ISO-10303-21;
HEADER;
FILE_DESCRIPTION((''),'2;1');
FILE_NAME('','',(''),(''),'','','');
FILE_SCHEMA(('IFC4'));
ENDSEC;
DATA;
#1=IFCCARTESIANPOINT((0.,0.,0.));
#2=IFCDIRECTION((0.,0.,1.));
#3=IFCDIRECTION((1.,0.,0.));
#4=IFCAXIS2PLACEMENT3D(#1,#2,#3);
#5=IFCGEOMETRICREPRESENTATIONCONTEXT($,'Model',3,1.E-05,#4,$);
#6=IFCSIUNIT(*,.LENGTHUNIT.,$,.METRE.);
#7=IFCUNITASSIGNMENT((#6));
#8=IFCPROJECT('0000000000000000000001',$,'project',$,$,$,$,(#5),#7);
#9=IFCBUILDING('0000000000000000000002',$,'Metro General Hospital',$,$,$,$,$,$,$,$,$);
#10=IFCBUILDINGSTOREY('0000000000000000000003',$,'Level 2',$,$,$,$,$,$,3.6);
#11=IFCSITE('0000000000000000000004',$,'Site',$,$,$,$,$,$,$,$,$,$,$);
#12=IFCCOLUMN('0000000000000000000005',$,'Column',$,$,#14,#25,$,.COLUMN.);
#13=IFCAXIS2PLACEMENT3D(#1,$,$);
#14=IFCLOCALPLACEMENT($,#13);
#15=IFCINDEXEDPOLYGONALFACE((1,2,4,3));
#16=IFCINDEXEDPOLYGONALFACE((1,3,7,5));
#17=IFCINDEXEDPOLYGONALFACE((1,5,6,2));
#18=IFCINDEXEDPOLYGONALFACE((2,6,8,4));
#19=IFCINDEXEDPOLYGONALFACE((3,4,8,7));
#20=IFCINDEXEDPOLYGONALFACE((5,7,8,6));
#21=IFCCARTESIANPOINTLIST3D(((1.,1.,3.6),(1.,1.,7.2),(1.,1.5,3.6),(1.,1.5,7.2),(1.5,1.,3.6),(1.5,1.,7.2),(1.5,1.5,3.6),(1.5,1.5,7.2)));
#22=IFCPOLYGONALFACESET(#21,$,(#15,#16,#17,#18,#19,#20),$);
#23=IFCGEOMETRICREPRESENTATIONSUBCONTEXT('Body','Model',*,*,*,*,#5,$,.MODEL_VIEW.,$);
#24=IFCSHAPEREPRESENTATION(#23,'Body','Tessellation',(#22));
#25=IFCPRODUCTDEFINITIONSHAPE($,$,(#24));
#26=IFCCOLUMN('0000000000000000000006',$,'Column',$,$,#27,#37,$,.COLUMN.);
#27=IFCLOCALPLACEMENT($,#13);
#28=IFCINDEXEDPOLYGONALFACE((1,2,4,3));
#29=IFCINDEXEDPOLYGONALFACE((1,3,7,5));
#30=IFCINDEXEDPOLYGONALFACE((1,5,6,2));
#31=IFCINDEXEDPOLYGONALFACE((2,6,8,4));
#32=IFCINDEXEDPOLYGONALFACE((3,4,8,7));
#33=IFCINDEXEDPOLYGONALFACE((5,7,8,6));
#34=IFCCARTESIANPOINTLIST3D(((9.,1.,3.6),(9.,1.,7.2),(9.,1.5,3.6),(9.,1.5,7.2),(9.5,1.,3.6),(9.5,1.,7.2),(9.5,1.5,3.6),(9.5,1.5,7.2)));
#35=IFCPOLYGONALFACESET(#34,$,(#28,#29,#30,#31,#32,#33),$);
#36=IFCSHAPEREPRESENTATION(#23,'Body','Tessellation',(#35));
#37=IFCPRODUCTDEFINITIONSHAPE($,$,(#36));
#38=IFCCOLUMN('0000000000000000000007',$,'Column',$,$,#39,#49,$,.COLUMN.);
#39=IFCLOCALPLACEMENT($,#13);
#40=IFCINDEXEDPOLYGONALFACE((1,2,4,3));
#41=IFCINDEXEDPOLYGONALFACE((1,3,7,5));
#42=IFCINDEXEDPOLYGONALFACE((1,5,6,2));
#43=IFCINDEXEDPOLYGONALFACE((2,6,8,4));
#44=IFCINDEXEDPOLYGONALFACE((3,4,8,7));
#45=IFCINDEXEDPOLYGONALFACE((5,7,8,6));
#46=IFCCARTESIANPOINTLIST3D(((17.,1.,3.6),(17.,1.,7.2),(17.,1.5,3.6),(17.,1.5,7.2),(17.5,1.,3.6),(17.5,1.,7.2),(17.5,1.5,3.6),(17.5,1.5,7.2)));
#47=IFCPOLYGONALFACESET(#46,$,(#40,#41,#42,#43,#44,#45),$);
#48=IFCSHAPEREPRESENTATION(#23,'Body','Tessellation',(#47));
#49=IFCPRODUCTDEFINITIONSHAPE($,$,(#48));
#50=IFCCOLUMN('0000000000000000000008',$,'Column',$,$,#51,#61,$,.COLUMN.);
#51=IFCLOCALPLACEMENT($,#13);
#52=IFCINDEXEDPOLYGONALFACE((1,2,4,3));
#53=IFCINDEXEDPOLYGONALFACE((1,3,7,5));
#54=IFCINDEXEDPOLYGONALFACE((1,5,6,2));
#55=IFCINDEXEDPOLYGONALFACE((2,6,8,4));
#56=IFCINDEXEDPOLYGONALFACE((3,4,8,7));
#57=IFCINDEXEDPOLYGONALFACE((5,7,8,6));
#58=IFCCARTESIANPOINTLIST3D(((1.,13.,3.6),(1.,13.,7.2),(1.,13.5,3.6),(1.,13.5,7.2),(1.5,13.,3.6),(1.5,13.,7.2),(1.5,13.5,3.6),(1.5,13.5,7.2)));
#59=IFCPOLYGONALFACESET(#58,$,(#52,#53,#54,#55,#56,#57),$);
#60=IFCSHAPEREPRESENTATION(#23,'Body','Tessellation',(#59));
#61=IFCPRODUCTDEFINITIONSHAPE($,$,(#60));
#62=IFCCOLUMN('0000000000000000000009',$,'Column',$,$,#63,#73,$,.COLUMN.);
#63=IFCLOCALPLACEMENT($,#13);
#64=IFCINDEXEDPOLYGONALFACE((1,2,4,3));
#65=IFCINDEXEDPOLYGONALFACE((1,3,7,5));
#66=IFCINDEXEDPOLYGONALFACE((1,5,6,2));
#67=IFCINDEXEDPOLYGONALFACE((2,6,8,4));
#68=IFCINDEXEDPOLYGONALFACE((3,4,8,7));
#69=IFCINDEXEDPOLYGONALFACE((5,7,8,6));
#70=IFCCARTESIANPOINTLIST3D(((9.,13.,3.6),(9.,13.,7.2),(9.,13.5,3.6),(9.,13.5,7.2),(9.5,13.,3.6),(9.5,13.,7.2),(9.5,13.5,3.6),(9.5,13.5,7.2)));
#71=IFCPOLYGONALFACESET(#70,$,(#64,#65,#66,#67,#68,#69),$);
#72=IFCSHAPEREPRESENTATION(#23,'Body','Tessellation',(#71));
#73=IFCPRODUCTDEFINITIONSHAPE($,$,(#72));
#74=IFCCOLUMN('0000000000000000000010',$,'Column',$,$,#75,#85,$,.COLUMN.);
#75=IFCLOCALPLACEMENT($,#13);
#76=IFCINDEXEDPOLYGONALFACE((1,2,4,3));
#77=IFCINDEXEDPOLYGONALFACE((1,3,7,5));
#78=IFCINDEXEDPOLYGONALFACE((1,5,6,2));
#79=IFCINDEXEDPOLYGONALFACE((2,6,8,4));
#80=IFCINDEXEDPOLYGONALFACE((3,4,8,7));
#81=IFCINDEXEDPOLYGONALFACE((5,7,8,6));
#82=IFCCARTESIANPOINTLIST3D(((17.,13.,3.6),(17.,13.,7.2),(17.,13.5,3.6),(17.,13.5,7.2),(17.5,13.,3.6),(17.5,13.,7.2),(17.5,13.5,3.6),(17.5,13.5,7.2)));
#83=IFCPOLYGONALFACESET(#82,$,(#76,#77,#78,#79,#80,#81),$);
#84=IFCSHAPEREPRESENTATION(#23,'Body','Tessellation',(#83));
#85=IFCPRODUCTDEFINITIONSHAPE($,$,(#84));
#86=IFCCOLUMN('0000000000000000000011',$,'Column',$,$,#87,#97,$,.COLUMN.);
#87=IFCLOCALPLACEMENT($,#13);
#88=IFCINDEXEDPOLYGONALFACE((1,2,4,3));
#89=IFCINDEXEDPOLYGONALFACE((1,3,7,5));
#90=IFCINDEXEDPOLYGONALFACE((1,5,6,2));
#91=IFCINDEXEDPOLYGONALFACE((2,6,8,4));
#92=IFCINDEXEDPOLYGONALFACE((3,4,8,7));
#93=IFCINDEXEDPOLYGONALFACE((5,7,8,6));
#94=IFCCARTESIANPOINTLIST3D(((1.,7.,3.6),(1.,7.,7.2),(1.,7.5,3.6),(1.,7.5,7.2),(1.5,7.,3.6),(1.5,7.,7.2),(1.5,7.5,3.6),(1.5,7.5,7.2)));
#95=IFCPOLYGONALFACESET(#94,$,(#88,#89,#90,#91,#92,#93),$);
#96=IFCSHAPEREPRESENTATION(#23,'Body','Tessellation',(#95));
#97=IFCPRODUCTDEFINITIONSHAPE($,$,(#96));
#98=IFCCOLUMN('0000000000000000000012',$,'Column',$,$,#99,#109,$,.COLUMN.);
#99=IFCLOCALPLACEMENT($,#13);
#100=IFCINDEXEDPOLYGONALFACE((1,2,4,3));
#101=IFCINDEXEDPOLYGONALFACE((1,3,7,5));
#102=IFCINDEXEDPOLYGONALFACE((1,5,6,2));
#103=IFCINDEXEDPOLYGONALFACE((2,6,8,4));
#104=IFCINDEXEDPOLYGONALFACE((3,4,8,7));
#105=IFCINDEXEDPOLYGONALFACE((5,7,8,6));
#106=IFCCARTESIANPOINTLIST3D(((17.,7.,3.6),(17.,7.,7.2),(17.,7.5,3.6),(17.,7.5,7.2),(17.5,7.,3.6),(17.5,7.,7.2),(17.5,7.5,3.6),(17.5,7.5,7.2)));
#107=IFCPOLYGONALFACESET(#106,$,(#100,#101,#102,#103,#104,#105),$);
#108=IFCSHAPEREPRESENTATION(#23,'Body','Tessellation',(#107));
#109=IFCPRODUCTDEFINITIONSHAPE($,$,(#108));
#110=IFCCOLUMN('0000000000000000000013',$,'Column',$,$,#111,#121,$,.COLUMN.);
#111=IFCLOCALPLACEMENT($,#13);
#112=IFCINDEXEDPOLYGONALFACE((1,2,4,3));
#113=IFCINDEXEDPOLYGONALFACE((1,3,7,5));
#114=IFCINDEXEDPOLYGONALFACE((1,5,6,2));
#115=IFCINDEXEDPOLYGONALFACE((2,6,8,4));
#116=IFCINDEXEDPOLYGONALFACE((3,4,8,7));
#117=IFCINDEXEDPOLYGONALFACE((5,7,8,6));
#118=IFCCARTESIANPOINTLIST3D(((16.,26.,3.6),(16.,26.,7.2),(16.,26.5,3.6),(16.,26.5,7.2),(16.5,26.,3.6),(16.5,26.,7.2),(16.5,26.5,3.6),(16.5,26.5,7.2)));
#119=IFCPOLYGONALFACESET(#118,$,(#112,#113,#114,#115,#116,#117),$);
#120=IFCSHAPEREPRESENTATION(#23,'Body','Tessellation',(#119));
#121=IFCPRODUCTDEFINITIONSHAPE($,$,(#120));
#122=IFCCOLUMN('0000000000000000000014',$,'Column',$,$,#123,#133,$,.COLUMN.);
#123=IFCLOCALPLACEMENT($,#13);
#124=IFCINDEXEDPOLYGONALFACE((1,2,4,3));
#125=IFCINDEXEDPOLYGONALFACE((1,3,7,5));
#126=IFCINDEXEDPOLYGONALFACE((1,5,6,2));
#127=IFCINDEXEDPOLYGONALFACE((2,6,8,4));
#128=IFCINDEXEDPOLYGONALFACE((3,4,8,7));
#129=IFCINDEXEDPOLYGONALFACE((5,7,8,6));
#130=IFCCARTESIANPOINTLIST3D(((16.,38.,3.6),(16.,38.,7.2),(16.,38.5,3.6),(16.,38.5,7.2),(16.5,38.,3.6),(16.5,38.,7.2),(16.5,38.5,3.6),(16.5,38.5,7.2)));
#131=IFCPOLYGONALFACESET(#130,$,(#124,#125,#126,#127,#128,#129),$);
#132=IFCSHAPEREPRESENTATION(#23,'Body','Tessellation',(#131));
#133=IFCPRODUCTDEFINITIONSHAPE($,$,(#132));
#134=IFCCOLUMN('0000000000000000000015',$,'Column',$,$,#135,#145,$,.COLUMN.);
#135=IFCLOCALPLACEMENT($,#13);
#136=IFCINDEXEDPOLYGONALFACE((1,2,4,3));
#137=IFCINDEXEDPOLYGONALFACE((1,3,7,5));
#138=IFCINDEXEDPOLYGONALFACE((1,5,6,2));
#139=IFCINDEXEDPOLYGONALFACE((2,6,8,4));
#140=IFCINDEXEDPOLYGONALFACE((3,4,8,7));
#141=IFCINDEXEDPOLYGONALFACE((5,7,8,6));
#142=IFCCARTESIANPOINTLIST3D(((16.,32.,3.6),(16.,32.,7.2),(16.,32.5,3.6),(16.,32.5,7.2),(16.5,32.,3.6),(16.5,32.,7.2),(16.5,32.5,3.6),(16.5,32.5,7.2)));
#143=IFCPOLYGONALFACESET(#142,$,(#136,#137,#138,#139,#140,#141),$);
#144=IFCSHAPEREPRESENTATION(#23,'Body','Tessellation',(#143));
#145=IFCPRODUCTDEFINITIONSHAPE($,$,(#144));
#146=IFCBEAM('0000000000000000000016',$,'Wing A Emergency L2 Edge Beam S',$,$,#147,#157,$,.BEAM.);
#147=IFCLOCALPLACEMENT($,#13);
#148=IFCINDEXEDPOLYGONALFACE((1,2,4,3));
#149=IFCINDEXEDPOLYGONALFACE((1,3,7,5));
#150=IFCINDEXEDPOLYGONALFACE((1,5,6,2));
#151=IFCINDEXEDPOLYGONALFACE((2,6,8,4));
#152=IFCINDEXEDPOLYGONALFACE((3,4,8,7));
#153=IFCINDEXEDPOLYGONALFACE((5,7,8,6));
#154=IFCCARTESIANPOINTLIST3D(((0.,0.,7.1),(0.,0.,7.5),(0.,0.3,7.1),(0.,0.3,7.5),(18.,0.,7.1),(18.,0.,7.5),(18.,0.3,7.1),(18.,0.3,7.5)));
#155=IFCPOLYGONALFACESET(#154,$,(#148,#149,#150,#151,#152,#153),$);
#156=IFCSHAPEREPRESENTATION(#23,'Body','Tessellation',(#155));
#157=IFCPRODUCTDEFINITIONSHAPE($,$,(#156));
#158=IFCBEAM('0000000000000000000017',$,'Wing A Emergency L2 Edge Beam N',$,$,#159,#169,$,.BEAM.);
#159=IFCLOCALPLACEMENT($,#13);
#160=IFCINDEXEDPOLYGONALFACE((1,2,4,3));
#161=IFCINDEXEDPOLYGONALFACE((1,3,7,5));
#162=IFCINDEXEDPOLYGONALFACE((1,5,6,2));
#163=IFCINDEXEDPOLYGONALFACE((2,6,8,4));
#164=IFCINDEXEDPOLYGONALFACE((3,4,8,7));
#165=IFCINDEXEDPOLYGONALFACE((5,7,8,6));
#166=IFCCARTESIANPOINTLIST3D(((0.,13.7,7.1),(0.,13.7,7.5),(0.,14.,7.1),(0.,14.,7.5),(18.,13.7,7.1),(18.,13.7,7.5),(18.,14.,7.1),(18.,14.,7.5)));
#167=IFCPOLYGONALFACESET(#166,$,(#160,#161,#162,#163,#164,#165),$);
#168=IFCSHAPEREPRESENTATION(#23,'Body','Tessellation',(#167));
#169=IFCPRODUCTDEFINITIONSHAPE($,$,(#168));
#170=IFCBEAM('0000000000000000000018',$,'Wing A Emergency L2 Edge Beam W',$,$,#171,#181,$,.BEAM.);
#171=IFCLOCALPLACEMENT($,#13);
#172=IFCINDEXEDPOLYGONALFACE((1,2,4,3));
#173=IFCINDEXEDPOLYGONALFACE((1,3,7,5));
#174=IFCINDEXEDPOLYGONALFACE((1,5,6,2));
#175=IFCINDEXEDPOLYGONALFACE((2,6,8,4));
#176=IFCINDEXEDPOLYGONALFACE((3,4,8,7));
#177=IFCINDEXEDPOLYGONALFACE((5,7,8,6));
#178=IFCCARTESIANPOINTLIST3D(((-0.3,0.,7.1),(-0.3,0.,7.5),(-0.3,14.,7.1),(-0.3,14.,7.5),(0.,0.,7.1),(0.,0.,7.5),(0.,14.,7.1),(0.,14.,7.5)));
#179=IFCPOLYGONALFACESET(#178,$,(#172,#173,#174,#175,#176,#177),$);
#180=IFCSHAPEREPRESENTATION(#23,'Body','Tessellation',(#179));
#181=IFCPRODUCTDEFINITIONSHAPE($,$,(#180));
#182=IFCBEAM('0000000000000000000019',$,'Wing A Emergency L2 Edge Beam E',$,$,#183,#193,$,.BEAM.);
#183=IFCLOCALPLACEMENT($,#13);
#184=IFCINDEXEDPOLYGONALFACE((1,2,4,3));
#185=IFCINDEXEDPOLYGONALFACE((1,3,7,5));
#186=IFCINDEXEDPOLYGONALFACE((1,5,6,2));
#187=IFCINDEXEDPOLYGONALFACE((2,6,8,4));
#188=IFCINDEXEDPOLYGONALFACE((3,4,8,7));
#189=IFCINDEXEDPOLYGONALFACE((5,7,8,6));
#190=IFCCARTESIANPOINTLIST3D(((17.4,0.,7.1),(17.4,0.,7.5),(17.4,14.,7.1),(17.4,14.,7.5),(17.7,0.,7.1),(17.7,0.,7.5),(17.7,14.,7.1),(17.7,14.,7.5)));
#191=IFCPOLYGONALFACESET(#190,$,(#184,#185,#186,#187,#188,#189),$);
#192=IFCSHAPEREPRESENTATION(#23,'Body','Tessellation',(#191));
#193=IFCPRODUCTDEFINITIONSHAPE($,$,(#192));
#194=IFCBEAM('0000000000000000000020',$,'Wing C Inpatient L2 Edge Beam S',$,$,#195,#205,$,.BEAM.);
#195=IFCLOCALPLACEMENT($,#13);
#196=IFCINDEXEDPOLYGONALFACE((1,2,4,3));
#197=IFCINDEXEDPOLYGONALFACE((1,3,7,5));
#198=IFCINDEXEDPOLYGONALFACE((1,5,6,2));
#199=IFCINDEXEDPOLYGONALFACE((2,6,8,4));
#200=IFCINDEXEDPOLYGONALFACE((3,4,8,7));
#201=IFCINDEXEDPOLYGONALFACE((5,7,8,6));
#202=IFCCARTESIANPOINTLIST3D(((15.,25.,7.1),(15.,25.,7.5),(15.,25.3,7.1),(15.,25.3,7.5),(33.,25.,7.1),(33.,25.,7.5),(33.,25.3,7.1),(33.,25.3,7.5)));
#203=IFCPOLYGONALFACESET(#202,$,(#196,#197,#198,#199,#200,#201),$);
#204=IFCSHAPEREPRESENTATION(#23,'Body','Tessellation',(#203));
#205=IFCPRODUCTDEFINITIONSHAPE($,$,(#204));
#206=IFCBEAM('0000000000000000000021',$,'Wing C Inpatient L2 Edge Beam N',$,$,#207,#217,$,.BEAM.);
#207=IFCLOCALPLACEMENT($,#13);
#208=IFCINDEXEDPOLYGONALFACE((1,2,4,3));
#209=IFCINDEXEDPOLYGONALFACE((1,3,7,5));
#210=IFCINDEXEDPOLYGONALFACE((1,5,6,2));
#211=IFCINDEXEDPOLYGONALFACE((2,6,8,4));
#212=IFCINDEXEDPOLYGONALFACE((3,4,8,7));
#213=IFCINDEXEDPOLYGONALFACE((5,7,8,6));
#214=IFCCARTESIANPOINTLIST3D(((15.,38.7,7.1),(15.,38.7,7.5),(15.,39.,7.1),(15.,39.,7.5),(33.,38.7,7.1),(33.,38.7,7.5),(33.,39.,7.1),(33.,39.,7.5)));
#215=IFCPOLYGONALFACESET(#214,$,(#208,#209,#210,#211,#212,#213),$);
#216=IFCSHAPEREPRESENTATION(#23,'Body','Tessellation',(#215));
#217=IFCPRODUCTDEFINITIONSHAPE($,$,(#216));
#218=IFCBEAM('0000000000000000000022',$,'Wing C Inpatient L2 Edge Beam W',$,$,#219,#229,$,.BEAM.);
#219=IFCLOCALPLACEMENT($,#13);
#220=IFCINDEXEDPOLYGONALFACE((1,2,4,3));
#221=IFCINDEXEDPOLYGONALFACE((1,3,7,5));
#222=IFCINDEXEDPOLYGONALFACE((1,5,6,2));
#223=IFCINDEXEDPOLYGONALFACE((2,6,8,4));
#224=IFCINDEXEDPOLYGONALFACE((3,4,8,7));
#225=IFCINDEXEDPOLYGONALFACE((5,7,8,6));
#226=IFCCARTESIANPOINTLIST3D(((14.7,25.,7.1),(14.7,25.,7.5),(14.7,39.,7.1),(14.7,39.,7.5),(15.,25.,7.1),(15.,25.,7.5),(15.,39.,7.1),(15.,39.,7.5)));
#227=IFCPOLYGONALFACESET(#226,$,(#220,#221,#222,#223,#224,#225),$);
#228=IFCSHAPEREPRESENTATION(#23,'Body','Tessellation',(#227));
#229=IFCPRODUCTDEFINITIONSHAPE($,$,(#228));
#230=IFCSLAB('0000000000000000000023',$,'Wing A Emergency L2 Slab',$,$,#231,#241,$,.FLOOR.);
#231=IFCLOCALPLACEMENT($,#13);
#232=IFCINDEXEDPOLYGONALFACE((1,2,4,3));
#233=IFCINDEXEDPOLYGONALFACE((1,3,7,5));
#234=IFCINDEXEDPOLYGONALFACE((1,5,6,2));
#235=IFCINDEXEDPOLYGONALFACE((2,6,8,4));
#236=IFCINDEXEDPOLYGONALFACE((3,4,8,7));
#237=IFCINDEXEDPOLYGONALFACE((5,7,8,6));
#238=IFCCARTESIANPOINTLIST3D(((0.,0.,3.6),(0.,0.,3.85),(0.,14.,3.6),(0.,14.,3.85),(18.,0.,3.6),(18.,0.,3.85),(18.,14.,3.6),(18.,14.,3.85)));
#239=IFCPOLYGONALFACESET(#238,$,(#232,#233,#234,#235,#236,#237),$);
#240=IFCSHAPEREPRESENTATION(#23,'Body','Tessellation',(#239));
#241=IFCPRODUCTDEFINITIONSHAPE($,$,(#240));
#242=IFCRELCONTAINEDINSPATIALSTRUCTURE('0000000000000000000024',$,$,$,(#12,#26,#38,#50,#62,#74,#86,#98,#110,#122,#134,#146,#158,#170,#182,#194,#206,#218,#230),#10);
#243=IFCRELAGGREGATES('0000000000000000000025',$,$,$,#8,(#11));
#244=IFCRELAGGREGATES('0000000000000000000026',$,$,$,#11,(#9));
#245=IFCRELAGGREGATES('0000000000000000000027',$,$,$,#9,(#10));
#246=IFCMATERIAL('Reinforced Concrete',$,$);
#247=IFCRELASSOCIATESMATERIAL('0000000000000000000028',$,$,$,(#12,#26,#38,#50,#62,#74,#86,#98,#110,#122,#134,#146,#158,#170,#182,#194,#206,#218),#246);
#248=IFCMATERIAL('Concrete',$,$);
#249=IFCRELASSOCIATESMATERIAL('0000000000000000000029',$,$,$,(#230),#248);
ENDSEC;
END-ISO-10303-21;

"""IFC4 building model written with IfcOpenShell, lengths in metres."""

from ifc_helpers import new_model, si_unit, frame, origin_with_axes, place, context, subcontext, project, spatial, line, indexed_curve, outline, extrude, material, element, save


model = new_model("IFC4")

# Units and contexts
model_context = context("Model", 3, precision=1e-05, world=origin_with_axes())
body_context = subcontext(model_context, "Body", "Model", "MODEL_VIEW")
ifc_project = project(units=[si_unit("LENGTHUNIT", "METRE")], contexts=[model_context])

# Site, building, storey
site = spatial("IfcSite", under=ifc_project, Name="Site")
building = spatial("IfcBuilding", under=site, Name="Metro General Hospital")
storey = spatial("IfcBuildingStorey", under=building, Name="Level 2", Elevation=3.6)

# Columns
ifc_material_1 = material(Name="Reinforced Concrete")
for number, where, z_axis, x_axis, name in (
    (1, (1.0, 1.0, 3.6), (0.0, 0.0, 1.0), (1.0, 0.0, 0.0), "Column"),
    (2, (9.0, 1.0, 3.6), (0.0, 0.0, 1.0), (1.0, 0.0, 0.0), "Column"),
    (3, (17.0, 1.0, 3.6), (0.0, 0.0, 1.0), (1.0, 0.0, 0.0), "Column"),
    (4, (1.0, 13.0, 3.6), (0.0, 0.0, 1.0), (1.0, 0.0, 0.0), "Column"),
    (5, (9.0, 13.0, 3.6), (0.0, 0.0, 1.0), (1.0, 0.0, 0.0), "Column"),
    (6, (17.0, 13.0, 3.6), (0.0, 0.0, 1.0), (1.0, 0.0, 0.0), "Column"),
    (7, (1.0, 7.0, 3.6), (0.0, 0.0, 1.0), (1.0, 0.0, 0.0), "Column"),
    (8, (17.0, 7.0, 3.6), (0.0, 0.0, 1.0), (1.0, 0.0, 0.0), "Column"),
    (9, (16.0, 26.0, 3.6), (0.0, 0.0, 1.0), (1.0, 0.0, 0.0), "Column"),
    (10, (16.0, 38.0, 3.6), (0.0, 0.0, 1.0), (1.0, 0.0, 0.0), "Column"),
    (11, (16.0, 32.0, 3.6), (0.0, 0.0, 1.0), (1.0, 0.0, 0.0), "Column"),
):
    element("IfcColumn", number, at=place(None, frame(where, z_axis=z_axis, x_axis=x_axis)), inside=storey, material=ifc_material_1, Name=name, PredefinedType="COLUMN", context=body_context, shape_type="SweptSolid", body=[
        extrude(outline(indexed_curve([(0.0, 0.0), (0.5, 0.0), (0.5, 0.5), (0.0, 0.5)], segments=[line(1, 2, 3, 4, 1)])), origin_with_axes(), (0.0, 0.0, 1.0), 3.6),
    ])

# Beams
for number, where, z_axis, x_axis, name in (
    (12, (0.0, 0.0, 7.1), (0.0, 0.0, 1.0), (1.0, 0.0, 0.0), "Wing A Emergency L2 Edge Beam S"),
    (13, (0.0, 13.7, 7.1), (0.0, 0.0, 1.0), (1.0, 0.0, 0.0), "Wing A Emergency L2 Edge Beam N"),
):
    element("IfcBeam", number, at=place(None, frame(where, z_axis=z_axis, x_axis=x_axis)), inside=storey, material=ifc_material_1, Name=name, PredefinedType="BEAM", context=body_context, shape_type="SweptSolid", body=[
        extrude(outline(indexed_curve([(0.0, 0.0), (18.0, 0.0), (18.0, 0.3), (0.0, 0.3)], segments=[line(1, 2, 3, 4, 1)])), origin_with_axes(), (0.0, 0.0, 1.0), 0.4),
    ])
for number, where, z_axis, x_axis, name in (
    (14, (0.0, 0.0, 7.1), (0.0, 0.0, 1.0), (0.0, 1.0, 0.0), "Wing A Emergency L2 Edge Beam W"),
    (15, (17.7, 0.0, 7.1), (0.0, 0.0, 1.0), (0.0, 1.0, 0.0), "Wing A Emergency L2 Edge Beam E"),
):
    element("IfcBeam", number, at=place(None, frame(where, z_axis=z_axis, x_axis=x_axis)), inside=storey, material=ifc_material_1, Name=name, PredefinedType="BEAM", context=body_context, shape_type="SweptSolid", body=[
        extrude(outline(indexed_curve([(0.0, 0.0), (14.0, 0.0), (14.0, 0.3), (0.0, 0.3)], segments=[line(1, 2, 3, 4, 1)])), origin_with_axes(), (0.0, 0.0, 1.0), 0.4),
    ])
for number, where, z_axis, x_axis, name in (
    (16, (15.0, 25.0, 7.1), (0.0, 0.0, 1.0), (1.0, 0.0, 0.0), "Wing C Inpatient L2 Edge Beam S"),
    (17, (15.0, 38.7, 7.1), (0.0, 0.0, 1.0), (1.0, 0.0, 0.0), "Wing C Inpatient L2 Edge Beam N"),
):
    element("IfcBeam", number, at=place(None, frame(where, z_axis=z_axis, x_axis=x_axis)), inside=storey, material=ifc_material_1, Name=name, PredefinedType="BEAM", context=body_context, shape_type="SweptSolid", body=[
        extrude(outline(indexed_curve([(0.0, 0.0), (18.0, 0.0), (18.0, 0.3), (0.0, 0.3)], segments=[line(1, 2, 3, 4, 1)])), origin_with_axes(), (0.0, 0.0, 1.0), 0.4),
    ])
beam_placement = place(None, frame((15.0, 25.0, 7.1), z_axis=(0.0, 0.0, 1.0), x_axis=(0.0, 1.0, 0.0)))
element("IfcBeam", 18, at=beam_placement, inside=storey, material=ifc_material_1, Name="Wing C Inpatient L2 Edge Beam W", PredefinedType="BEAM", context=body_context, shape_type="SweptSolid", body=[
    extrude(outline(indexed_curve([(0.0, 0.0), (14.0, 0.0), (14.0, 0.3), (0.0, 0.3)], segments=[line(1, 2, 3, 4, 1)])), origin_with_axes(), (0.0, 0.0, 1.0), 0.4),
])

# Slab
ifc_material_2 = material(Name="Concrete")
for number, where, z_axis, x_axis, name in (
    (19, (0.0, 0.0, 3.6), (0.0, 0.0, 1.0), (1.0, 0.0, 0.0), "Wing A Emergency L2 Slab"),
):
    element("IfcSlab", number, at=place(None, frame(where, z_axis=z_axis, x_axis=x_axis)), inside=storey, material=ifc_material_2, Name=name, PredefinedType="FLOOR", context=body_context, shape_type="SweptSolid", body=[
        extrude(outline(indexed_curve([(0.0, 0.0), (18.0, 0.0), (18.0, 14.0), (0.0, 14.0)], segments=[line(1, 2, 3, 4, 1)])), origin_with_axes(), (0.0, 0.0, 1.0), 0.25),
    ])

save(model, "model.ifc")
